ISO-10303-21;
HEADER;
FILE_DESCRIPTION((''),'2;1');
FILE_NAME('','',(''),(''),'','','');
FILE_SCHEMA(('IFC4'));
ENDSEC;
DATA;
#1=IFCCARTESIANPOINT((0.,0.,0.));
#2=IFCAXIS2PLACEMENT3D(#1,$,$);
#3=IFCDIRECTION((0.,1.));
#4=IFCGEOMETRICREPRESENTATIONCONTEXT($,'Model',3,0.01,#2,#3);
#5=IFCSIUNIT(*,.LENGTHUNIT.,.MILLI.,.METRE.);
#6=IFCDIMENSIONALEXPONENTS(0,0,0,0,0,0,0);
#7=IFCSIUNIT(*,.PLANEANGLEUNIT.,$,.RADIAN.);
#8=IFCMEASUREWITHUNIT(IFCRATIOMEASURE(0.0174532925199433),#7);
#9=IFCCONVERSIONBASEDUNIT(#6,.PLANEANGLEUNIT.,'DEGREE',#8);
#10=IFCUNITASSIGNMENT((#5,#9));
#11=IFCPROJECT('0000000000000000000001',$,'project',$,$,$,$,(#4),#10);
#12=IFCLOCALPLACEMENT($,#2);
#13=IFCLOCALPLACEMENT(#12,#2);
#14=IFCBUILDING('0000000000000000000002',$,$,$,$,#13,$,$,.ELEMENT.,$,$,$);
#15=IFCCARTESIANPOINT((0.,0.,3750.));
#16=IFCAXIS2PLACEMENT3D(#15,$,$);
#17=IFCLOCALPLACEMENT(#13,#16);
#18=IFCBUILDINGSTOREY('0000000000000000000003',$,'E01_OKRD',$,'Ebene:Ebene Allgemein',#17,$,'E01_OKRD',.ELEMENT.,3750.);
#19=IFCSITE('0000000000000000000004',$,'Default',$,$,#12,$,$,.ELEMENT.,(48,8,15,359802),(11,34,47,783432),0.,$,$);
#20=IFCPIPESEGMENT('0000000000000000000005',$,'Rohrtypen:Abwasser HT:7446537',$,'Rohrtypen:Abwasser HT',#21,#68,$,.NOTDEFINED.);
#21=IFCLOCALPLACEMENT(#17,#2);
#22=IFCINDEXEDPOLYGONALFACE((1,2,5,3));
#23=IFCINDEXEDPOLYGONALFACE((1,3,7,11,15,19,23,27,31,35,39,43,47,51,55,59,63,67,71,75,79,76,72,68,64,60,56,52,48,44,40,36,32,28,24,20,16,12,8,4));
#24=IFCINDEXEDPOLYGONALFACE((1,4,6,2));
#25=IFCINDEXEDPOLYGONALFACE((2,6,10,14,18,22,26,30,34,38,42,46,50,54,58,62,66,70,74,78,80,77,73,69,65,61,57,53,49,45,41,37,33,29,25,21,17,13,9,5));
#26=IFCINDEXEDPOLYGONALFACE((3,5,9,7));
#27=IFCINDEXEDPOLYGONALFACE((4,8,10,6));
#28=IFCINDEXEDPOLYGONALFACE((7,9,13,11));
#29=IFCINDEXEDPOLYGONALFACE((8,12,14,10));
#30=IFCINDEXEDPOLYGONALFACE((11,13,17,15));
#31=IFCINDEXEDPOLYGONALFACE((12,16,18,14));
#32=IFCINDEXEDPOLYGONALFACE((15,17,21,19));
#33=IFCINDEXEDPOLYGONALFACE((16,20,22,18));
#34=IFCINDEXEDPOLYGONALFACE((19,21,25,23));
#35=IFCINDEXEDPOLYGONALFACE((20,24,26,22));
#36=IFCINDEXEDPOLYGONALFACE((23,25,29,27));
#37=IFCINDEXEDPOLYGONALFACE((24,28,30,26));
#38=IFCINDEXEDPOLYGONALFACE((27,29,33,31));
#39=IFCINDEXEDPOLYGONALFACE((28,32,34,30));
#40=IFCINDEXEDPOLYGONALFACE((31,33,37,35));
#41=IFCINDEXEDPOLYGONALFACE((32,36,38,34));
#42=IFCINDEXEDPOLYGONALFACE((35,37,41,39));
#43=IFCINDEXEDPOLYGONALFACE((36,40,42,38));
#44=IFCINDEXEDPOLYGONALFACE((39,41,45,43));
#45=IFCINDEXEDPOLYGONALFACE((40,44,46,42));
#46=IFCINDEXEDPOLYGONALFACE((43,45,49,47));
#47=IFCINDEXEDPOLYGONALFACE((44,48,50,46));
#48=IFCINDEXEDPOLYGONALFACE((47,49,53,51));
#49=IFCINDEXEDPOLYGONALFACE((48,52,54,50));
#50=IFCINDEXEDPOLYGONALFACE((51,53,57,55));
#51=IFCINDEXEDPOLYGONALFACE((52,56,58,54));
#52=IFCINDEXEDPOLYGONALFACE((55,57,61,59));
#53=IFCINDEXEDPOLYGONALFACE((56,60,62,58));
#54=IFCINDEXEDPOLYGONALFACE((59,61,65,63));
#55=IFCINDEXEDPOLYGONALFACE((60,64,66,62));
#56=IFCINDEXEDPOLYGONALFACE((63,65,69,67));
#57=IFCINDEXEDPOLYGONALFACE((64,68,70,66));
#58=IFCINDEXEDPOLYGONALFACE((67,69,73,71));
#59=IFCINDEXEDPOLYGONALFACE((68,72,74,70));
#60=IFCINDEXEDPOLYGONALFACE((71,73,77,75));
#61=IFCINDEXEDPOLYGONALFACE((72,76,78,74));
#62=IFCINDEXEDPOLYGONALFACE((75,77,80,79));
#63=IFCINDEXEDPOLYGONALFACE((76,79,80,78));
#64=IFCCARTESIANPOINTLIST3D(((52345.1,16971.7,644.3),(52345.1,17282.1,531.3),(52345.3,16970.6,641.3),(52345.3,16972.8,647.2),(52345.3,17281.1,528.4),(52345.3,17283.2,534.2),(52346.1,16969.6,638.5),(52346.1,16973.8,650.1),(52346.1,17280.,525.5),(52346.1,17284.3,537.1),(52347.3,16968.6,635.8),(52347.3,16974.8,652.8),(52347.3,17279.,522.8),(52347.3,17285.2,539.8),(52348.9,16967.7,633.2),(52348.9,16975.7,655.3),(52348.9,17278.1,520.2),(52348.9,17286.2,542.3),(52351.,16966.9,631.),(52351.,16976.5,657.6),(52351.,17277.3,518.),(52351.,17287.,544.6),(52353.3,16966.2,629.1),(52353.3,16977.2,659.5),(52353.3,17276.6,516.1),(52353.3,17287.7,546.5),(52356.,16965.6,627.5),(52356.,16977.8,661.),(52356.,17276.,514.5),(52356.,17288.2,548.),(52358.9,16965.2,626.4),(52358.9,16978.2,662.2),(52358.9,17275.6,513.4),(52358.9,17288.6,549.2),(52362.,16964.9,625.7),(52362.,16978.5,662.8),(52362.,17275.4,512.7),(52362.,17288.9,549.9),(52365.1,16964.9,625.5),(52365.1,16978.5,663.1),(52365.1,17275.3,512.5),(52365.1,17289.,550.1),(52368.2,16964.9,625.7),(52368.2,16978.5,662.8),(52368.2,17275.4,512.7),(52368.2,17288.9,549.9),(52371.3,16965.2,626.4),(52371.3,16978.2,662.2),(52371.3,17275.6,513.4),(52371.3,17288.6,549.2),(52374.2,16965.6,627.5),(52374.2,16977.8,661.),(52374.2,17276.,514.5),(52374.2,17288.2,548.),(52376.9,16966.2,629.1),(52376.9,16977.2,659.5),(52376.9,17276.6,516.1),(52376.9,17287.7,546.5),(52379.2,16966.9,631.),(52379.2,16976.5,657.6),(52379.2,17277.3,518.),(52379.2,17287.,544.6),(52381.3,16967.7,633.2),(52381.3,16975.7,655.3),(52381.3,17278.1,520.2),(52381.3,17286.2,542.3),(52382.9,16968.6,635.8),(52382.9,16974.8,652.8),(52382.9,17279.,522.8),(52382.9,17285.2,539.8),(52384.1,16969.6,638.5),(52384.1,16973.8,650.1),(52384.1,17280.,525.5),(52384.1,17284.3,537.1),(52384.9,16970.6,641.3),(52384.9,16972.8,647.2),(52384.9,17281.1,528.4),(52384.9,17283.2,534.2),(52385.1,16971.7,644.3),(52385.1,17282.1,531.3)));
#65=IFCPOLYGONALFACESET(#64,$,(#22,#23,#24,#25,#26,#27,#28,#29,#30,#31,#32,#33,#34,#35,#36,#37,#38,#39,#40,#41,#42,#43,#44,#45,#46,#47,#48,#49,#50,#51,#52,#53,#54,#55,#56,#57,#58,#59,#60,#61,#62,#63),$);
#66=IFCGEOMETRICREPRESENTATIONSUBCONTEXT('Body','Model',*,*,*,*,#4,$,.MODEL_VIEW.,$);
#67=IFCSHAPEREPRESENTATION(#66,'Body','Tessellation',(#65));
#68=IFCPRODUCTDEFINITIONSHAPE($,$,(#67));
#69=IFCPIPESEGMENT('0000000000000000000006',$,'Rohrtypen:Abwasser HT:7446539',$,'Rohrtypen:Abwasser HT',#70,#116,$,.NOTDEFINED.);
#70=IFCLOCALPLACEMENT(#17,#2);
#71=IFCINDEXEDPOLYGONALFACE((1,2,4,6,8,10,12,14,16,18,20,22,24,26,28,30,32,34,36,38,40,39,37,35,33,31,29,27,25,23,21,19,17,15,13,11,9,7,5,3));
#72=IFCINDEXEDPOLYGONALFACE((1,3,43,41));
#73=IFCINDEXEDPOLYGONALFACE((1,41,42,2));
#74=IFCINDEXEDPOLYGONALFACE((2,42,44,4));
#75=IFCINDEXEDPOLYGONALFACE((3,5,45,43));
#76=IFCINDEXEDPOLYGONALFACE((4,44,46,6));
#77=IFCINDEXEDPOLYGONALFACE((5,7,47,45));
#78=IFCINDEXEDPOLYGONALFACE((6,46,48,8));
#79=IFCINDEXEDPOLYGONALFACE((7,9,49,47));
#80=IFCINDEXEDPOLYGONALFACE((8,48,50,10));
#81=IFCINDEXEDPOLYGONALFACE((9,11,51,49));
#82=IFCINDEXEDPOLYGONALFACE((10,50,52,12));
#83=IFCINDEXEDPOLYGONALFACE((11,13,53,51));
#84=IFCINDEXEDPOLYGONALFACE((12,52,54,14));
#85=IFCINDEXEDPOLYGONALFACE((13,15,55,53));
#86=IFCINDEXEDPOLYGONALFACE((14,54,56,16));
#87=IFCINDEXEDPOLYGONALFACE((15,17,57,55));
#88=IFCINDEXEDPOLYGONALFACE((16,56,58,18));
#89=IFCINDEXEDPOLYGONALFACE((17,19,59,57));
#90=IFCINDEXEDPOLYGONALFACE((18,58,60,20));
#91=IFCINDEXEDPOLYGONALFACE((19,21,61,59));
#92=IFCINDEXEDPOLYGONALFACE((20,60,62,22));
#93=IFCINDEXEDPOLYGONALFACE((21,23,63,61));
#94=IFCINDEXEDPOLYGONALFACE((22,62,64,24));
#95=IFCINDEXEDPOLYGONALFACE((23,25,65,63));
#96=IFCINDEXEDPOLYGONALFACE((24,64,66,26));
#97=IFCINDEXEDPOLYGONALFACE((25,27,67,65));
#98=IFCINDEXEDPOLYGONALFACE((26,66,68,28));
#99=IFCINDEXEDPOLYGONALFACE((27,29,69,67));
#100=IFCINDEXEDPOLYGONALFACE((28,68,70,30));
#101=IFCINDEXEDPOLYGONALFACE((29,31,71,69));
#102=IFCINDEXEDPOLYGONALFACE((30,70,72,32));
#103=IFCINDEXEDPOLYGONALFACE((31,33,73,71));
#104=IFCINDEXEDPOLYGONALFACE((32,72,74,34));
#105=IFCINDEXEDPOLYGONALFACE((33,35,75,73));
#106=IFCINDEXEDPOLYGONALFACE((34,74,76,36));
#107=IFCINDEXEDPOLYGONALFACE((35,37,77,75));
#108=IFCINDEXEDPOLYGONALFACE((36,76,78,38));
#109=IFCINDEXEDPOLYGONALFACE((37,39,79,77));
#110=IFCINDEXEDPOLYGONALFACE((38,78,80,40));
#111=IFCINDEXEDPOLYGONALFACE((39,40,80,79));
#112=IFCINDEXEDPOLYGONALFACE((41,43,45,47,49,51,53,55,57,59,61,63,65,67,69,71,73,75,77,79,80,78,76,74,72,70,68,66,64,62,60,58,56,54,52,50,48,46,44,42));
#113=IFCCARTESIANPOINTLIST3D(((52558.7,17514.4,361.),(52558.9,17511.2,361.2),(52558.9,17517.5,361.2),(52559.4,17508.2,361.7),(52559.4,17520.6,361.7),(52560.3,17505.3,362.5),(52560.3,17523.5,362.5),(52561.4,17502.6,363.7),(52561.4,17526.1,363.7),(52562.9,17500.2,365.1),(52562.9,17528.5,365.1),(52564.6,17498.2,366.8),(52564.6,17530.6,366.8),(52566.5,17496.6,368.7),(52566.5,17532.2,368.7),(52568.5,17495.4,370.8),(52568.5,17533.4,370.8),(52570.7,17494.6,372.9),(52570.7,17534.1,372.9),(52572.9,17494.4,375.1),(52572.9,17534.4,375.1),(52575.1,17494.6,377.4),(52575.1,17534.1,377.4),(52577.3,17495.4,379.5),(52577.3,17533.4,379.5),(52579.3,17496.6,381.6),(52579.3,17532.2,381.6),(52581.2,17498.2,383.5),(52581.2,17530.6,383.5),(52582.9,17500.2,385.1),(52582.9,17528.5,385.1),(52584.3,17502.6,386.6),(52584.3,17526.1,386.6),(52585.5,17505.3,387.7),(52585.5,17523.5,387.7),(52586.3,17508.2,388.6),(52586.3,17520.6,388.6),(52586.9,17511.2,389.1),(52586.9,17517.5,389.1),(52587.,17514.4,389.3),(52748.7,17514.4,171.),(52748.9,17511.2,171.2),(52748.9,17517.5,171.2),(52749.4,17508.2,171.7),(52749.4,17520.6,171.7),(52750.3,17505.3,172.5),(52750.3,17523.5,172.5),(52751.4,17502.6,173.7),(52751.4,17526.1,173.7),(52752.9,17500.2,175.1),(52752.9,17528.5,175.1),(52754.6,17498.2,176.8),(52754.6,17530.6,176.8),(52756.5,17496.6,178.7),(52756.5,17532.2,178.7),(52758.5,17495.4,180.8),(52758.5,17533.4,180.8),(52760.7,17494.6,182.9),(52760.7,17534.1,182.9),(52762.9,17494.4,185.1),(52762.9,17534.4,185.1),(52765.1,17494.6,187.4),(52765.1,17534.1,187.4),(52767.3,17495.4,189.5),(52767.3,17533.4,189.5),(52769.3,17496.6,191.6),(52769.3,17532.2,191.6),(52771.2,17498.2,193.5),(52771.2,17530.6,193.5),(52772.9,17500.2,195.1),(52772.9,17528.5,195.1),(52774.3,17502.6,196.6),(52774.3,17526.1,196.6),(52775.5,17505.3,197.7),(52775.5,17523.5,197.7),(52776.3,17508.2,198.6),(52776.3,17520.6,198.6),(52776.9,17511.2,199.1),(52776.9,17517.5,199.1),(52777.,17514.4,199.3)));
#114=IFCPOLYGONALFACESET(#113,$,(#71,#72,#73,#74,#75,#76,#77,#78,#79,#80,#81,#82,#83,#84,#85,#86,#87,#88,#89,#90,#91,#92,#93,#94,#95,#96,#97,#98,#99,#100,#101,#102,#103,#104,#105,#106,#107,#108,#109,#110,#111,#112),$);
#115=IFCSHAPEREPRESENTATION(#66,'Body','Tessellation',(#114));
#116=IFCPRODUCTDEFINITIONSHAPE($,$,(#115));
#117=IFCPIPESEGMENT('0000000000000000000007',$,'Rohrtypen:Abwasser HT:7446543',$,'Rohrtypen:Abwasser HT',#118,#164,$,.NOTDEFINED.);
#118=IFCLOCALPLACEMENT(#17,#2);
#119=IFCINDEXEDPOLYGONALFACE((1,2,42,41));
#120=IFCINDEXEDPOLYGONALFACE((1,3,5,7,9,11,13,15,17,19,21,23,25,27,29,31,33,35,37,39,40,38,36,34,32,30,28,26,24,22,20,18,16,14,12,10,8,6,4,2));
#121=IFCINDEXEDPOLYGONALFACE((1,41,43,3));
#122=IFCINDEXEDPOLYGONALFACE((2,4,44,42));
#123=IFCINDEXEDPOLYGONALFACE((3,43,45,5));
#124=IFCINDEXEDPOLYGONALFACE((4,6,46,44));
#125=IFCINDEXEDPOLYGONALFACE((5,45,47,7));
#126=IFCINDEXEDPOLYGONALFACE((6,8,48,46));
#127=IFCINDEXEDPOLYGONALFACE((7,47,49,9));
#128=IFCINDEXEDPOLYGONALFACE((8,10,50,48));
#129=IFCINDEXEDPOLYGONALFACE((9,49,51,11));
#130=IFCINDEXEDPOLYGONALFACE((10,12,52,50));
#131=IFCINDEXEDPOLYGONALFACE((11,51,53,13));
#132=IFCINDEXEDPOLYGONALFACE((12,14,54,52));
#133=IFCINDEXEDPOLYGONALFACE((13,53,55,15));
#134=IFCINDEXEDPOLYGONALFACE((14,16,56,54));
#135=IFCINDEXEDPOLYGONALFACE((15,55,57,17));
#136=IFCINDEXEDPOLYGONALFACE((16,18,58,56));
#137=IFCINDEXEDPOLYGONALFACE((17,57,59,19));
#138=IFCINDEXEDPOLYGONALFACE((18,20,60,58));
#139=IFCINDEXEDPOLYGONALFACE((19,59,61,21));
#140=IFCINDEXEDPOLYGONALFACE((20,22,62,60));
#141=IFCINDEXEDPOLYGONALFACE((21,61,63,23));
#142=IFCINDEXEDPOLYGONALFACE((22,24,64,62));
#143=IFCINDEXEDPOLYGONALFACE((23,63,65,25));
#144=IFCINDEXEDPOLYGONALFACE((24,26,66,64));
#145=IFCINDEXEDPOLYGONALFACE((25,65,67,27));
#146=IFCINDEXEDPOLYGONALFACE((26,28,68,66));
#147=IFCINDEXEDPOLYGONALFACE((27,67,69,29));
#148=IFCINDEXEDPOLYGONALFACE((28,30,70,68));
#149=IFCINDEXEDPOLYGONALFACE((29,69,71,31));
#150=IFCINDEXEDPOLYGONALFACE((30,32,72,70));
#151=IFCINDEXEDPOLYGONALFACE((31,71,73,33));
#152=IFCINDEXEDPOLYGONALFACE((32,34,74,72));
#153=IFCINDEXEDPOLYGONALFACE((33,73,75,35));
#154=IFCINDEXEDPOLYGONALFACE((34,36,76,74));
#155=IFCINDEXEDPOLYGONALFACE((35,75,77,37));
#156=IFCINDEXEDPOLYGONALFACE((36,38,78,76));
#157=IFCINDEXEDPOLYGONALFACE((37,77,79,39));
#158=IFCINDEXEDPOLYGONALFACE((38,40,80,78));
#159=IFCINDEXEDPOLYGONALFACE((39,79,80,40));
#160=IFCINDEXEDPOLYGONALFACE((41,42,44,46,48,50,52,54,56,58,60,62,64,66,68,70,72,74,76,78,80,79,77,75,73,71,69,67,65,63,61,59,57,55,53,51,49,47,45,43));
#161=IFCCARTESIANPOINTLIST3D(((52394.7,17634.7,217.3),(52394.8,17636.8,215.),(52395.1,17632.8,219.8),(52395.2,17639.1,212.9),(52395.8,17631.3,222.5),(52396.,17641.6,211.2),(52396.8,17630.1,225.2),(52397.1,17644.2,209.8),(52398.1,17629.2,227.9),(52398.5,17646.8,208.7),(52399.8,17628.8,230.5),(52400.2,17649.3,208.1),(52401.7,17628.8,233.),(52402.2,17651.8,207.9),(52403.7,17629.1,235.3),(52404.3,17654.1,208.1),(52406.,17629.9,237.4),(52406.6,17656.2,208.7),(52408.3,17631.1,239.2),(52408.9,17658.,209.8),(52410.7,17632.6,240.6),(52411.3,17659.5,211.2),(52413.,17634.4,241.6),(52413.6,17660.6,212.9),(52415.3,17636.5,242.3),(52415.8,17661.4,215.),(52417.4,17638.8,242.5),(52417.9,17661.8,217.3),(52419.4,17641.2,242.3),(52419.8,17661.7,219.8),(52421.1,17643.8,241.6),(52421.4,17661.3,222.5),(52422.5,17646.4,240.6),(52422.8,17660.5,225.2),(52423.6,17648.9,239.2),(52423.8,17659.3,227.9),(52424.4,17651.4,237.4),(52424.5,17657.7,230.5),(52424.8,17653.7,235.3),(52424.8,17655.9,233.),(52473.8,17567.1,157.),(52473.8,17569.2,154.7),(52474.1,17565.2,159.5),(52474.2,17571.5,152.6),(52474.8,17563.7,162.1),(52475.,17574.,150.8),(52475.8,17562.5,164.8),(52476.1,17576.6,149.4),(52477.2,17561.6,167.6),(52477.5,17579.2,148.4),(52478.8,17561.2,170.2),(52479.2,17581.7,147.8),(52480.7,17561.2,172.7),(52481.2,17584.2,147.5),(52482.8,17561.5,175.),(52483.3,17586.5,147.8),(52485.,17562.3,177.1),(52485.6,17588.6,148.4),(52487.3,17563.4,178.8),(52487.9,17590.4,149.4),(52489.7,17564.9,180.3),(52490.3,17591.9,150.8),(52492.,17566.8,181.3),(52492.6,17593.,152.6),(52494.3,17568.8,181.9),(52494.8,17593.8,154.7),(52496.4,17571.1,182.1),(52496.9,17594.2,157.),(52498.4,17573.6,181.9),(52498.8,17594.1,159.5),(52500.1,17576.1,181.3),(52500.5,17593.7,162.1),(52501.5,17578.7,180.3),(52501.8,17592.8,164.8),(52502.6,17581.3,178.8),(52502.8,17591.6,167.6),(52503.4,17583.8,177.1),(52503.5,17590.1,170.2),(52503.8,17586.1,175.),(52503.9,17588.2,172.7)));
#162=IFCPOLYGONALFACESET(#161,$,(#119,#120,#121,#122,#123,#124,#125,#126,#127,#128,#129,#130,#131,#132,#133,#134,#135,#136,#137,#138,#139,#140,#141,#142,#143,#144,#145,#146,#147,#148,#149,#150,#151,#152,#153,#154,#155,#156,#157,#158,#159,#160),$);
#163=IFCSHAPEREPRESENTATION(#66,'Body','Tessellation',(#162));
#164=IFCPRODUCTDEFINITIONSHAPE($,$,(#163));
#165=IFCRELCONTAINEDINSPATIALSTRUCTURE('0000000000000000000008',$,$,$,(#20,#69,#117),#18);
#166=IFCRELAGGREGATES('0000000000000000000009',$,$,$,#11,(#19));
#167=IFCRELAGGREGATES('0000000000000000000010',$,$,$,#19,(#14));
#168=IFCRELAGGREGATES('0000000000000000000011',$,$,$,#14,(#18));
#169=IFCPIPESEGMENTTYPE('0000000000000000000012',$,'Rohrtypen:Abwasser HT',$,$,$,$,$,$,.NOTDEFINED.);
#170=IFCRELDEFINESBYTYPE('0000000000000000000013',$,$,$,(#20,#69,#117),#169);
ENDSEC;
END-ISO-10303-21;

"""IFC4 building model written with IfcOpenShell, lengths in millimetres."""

from ifc_helpers import new_model, entity, si_unit, converted_unit, direction, frame, origin, place, context, subcontext, project, spatial, indexed_curve, outline, extrude, type_object, element, save


model = new_model("IFC4")

# Units and contexts
model_context = context("Model", 3, precision=0.01, world=origin(), true_north=direction((0.0, 1.0)))
body_context = subcontext(model_context, "Body", "Model", "MODEL_VIEW")
ifc_project = project(units=[si_unit("LENGTHUNIT", "METRE", prefix="MILLI"), converted_unit("PLANEANGLEUNIT", "DEGREE", entity("IfcRatioMeasure", 0.0174532925199433), si_unit("PLANEANGLEUNIT", "RADIAN"), dimensions=[0, 0, 0, 0, 0, 0, 0])], contexts=[model_context])

# Site, building, storey
site_placement = place(None, origin())
site = spatial("IfcSite", under=ifc_project, at=site_placement, Name="Default", CompositionType="ELEMENT", RefLatitude=(48, 8, 15, 359802), RefLongitude=(11, 34, 47, 783432), RefElevation=0.0)
building_placement = place(site_placement, origin())
building = spatial("IfcBuilding", under=site, at=building_placement, CompositionType="ELEMENT")
storey_placement = place(building_placement, frame((0.0, 0.0, 3750.0)))
storey = spatial("IfcBuildingStorey", under=building, at=storey_placement, Name="E01_OKRD", ObjectType="Ebene:Ebene Allgemein", LongName="E01_OKRD", CompositionType="ELEMENT", Elevation=3750.0)

# Pipe segments
pipe_segment_type_1 = type_object("IfcPipeSegmentType", Name="Rohrtypen:Abwasser HT", PredefinedType="NOTDEFINED")
pipe_segment_1_placement = place(storey_placement, origin())
element("IfcPipeSegment", 1, at=pipe_segment_1_placement, inside=storey, type_object=pipe_segment_type_1, Name="Rohrtypen:Abwasser HT:7446537", ObjectType="Rohrtypen:Abwasser HT", PredefinedType="NOTDEFINED", context=body_context, shape_type="SweptSolid", body=[
    extrude(outline(indexed_curve([(20.0, 0.0), (19.8, 3.1), (19.0, 6.2), (17.8, 9.1), (16.2, 11.8), (14.1, 14.1), (11.8, 16.2), (9.1, 17.8), (6.2, 19.0), (3.1, 19.8), (0.0, 20.0), (-3.1, 19.8), (-6.2, 19.0), (-9.1, 17.8), (-11.8, 16.2), (-14.1, 14.1), (-16.2, 11.8), (-17.8, 9.1), (-19.0, 6.2), (-19.8, 3.1), (-20.0, 0.0), (-19.8, -3.1), (-19.0, -6.2), (-17.8, -9.1), (-16.2, -11.8), (-14.1, -14.1), (-11.8, -16.2), (-9.1, -17.8), (-6.2, -19.0), (-3.1, -19.8), (0.0, -20.0), (3.1, -19.8), (6.2, -19.0), (9.1, -17.8), (11.8, -16.2), (14.1, -14.1), (16.2, -11.8), (17.8, -9.1), (19.0, -6.2), (19.8, -3.1), (20.0, 0.0)], self_intersect=False)), frame((52365.1, 16971.7, 644.3), z_axis=(0.0, 0.939693, -0.34202), x_axis=(1.0, 0.0, 0.0)), (0.0, 0.0, 1.0), 330.4),
])
pipe_segment_2_placement = place(storey_placement, origin())
element("IfcPipeSegment", 2, at=pipe_segment_2_placement, inside=storey, type_object=pipe_segment_type_1, Name="Rohrtypen:Abwasser HT:7446539", ObjectType="Rohrtypen:Abwasser HT", PredefinedType="NOTDEFINED", context=body_context, shape_type="SweptSolid", body=[
    extrude(outline(indexed_curve([(20.0, 0.0), (19.8, 3.1), (19.0, 6.2), (17.8, 9.1), (16.2, 11.8), (14.1, 14.1), (11.8, 16.2), (9.1, 17.8), (6.2, 19.0), (3.1, 19.8), (0.0, 20.0), (-3.1, 19.8), (-6.2, 19.0), (-9.1, 17.8), (-11.8, 16.2), (-14.1, 14.1), (-16.2, 11.8), (-17.8, 9.1), (-19.0, 6.2), (-19.8, 3.1), (-20.0, 0.0), (-19.8, -3.1), (-19.0, -6.2), (-17.8, -9.1), (-16.2, -11.8), (-14.1, -14.1), (-11.8, -16.2), (-9.1, -17.8), (-6.2, -19.0), (-3.1, -19.8), (0.0, -20.0), (3.1, -19.8), (6.2, -19.0), (9.1, -17.8), (11.8, -16.2), (14.1, -14.1), (16.2, -11.8), (17.8, -9.1), (19.0, -6.2), (19.8, -3.1), (20.0, 0.0)], self_intersect=False)), frame((52762.9, 17514.4, 185.1), z_axis=(-0.707107, 0.0, 0.707107), x_axis=(0.0, 1.0, 0.0)), (0.0, 0.0, 1.0), 268.7),
])
pipe_segment_3_placement = place(storey_placement, origin())
element("IfcPipeSegment", 3, at=pipe_segment_3_placement, inside=storey, type_object=pipe_segment_type_1, Name="Rohrtypen:Abwasser HT:7446543", ObjectType="Rohrtypen:Abwasser HT", PredefinedType="NOTDEFINED", context=body_context, shape_type="SweptSolid", body=[
    extrude(outline(indexed_curve([(20.0, 0.0), (19.8, 3.1), (19.0, 6.2), (17.8, 9.1), (16.2, 11.8), (14.1, 14.1), (11.8, 16.2), (9.1, 17.8), (6.2, 19.0), (3.1, 19.8), (0.0, 20.0), (-3.1, 19.8), (-6.2, 19.0), (-9.1, 17.8), (-11.8, 16.2), (-14.1, 14.1), (-16.2, 11.8), (-17.8, 9.1), (-19.0, 6.2), (-19.8, 3.1), (-20.0, 0.0), (-19.8, -3.1), (-19.0, -6.2), (-17.8, -9.1), (-16.2, -11.8), (-14.1, -14.1), (-11.8, -16.2), (-9.1, -17.8), (-6.2, -19.0), (-3.1, -19.8), (0.0, -20.0), (3.1, -19.8), (6.2, -19.0), (9.1, -17.8), (11.8, -16.2), (14.1, -14.1), (16.2, -11.8), (17.8, -9.1), (19.0, -6.2), (19.8, -3.1), (20.0, 0.0)], self_intersect=False)), frame((52488.8, 17577.7, 164.8), z_axis=(-0.65717, 0.562452, 0.501772), x_axis=(-0.650234, -0.759734, 0.0)), (0.0, 0.0, 1.0), 120.2),
])

save(model, "model.ifc")
